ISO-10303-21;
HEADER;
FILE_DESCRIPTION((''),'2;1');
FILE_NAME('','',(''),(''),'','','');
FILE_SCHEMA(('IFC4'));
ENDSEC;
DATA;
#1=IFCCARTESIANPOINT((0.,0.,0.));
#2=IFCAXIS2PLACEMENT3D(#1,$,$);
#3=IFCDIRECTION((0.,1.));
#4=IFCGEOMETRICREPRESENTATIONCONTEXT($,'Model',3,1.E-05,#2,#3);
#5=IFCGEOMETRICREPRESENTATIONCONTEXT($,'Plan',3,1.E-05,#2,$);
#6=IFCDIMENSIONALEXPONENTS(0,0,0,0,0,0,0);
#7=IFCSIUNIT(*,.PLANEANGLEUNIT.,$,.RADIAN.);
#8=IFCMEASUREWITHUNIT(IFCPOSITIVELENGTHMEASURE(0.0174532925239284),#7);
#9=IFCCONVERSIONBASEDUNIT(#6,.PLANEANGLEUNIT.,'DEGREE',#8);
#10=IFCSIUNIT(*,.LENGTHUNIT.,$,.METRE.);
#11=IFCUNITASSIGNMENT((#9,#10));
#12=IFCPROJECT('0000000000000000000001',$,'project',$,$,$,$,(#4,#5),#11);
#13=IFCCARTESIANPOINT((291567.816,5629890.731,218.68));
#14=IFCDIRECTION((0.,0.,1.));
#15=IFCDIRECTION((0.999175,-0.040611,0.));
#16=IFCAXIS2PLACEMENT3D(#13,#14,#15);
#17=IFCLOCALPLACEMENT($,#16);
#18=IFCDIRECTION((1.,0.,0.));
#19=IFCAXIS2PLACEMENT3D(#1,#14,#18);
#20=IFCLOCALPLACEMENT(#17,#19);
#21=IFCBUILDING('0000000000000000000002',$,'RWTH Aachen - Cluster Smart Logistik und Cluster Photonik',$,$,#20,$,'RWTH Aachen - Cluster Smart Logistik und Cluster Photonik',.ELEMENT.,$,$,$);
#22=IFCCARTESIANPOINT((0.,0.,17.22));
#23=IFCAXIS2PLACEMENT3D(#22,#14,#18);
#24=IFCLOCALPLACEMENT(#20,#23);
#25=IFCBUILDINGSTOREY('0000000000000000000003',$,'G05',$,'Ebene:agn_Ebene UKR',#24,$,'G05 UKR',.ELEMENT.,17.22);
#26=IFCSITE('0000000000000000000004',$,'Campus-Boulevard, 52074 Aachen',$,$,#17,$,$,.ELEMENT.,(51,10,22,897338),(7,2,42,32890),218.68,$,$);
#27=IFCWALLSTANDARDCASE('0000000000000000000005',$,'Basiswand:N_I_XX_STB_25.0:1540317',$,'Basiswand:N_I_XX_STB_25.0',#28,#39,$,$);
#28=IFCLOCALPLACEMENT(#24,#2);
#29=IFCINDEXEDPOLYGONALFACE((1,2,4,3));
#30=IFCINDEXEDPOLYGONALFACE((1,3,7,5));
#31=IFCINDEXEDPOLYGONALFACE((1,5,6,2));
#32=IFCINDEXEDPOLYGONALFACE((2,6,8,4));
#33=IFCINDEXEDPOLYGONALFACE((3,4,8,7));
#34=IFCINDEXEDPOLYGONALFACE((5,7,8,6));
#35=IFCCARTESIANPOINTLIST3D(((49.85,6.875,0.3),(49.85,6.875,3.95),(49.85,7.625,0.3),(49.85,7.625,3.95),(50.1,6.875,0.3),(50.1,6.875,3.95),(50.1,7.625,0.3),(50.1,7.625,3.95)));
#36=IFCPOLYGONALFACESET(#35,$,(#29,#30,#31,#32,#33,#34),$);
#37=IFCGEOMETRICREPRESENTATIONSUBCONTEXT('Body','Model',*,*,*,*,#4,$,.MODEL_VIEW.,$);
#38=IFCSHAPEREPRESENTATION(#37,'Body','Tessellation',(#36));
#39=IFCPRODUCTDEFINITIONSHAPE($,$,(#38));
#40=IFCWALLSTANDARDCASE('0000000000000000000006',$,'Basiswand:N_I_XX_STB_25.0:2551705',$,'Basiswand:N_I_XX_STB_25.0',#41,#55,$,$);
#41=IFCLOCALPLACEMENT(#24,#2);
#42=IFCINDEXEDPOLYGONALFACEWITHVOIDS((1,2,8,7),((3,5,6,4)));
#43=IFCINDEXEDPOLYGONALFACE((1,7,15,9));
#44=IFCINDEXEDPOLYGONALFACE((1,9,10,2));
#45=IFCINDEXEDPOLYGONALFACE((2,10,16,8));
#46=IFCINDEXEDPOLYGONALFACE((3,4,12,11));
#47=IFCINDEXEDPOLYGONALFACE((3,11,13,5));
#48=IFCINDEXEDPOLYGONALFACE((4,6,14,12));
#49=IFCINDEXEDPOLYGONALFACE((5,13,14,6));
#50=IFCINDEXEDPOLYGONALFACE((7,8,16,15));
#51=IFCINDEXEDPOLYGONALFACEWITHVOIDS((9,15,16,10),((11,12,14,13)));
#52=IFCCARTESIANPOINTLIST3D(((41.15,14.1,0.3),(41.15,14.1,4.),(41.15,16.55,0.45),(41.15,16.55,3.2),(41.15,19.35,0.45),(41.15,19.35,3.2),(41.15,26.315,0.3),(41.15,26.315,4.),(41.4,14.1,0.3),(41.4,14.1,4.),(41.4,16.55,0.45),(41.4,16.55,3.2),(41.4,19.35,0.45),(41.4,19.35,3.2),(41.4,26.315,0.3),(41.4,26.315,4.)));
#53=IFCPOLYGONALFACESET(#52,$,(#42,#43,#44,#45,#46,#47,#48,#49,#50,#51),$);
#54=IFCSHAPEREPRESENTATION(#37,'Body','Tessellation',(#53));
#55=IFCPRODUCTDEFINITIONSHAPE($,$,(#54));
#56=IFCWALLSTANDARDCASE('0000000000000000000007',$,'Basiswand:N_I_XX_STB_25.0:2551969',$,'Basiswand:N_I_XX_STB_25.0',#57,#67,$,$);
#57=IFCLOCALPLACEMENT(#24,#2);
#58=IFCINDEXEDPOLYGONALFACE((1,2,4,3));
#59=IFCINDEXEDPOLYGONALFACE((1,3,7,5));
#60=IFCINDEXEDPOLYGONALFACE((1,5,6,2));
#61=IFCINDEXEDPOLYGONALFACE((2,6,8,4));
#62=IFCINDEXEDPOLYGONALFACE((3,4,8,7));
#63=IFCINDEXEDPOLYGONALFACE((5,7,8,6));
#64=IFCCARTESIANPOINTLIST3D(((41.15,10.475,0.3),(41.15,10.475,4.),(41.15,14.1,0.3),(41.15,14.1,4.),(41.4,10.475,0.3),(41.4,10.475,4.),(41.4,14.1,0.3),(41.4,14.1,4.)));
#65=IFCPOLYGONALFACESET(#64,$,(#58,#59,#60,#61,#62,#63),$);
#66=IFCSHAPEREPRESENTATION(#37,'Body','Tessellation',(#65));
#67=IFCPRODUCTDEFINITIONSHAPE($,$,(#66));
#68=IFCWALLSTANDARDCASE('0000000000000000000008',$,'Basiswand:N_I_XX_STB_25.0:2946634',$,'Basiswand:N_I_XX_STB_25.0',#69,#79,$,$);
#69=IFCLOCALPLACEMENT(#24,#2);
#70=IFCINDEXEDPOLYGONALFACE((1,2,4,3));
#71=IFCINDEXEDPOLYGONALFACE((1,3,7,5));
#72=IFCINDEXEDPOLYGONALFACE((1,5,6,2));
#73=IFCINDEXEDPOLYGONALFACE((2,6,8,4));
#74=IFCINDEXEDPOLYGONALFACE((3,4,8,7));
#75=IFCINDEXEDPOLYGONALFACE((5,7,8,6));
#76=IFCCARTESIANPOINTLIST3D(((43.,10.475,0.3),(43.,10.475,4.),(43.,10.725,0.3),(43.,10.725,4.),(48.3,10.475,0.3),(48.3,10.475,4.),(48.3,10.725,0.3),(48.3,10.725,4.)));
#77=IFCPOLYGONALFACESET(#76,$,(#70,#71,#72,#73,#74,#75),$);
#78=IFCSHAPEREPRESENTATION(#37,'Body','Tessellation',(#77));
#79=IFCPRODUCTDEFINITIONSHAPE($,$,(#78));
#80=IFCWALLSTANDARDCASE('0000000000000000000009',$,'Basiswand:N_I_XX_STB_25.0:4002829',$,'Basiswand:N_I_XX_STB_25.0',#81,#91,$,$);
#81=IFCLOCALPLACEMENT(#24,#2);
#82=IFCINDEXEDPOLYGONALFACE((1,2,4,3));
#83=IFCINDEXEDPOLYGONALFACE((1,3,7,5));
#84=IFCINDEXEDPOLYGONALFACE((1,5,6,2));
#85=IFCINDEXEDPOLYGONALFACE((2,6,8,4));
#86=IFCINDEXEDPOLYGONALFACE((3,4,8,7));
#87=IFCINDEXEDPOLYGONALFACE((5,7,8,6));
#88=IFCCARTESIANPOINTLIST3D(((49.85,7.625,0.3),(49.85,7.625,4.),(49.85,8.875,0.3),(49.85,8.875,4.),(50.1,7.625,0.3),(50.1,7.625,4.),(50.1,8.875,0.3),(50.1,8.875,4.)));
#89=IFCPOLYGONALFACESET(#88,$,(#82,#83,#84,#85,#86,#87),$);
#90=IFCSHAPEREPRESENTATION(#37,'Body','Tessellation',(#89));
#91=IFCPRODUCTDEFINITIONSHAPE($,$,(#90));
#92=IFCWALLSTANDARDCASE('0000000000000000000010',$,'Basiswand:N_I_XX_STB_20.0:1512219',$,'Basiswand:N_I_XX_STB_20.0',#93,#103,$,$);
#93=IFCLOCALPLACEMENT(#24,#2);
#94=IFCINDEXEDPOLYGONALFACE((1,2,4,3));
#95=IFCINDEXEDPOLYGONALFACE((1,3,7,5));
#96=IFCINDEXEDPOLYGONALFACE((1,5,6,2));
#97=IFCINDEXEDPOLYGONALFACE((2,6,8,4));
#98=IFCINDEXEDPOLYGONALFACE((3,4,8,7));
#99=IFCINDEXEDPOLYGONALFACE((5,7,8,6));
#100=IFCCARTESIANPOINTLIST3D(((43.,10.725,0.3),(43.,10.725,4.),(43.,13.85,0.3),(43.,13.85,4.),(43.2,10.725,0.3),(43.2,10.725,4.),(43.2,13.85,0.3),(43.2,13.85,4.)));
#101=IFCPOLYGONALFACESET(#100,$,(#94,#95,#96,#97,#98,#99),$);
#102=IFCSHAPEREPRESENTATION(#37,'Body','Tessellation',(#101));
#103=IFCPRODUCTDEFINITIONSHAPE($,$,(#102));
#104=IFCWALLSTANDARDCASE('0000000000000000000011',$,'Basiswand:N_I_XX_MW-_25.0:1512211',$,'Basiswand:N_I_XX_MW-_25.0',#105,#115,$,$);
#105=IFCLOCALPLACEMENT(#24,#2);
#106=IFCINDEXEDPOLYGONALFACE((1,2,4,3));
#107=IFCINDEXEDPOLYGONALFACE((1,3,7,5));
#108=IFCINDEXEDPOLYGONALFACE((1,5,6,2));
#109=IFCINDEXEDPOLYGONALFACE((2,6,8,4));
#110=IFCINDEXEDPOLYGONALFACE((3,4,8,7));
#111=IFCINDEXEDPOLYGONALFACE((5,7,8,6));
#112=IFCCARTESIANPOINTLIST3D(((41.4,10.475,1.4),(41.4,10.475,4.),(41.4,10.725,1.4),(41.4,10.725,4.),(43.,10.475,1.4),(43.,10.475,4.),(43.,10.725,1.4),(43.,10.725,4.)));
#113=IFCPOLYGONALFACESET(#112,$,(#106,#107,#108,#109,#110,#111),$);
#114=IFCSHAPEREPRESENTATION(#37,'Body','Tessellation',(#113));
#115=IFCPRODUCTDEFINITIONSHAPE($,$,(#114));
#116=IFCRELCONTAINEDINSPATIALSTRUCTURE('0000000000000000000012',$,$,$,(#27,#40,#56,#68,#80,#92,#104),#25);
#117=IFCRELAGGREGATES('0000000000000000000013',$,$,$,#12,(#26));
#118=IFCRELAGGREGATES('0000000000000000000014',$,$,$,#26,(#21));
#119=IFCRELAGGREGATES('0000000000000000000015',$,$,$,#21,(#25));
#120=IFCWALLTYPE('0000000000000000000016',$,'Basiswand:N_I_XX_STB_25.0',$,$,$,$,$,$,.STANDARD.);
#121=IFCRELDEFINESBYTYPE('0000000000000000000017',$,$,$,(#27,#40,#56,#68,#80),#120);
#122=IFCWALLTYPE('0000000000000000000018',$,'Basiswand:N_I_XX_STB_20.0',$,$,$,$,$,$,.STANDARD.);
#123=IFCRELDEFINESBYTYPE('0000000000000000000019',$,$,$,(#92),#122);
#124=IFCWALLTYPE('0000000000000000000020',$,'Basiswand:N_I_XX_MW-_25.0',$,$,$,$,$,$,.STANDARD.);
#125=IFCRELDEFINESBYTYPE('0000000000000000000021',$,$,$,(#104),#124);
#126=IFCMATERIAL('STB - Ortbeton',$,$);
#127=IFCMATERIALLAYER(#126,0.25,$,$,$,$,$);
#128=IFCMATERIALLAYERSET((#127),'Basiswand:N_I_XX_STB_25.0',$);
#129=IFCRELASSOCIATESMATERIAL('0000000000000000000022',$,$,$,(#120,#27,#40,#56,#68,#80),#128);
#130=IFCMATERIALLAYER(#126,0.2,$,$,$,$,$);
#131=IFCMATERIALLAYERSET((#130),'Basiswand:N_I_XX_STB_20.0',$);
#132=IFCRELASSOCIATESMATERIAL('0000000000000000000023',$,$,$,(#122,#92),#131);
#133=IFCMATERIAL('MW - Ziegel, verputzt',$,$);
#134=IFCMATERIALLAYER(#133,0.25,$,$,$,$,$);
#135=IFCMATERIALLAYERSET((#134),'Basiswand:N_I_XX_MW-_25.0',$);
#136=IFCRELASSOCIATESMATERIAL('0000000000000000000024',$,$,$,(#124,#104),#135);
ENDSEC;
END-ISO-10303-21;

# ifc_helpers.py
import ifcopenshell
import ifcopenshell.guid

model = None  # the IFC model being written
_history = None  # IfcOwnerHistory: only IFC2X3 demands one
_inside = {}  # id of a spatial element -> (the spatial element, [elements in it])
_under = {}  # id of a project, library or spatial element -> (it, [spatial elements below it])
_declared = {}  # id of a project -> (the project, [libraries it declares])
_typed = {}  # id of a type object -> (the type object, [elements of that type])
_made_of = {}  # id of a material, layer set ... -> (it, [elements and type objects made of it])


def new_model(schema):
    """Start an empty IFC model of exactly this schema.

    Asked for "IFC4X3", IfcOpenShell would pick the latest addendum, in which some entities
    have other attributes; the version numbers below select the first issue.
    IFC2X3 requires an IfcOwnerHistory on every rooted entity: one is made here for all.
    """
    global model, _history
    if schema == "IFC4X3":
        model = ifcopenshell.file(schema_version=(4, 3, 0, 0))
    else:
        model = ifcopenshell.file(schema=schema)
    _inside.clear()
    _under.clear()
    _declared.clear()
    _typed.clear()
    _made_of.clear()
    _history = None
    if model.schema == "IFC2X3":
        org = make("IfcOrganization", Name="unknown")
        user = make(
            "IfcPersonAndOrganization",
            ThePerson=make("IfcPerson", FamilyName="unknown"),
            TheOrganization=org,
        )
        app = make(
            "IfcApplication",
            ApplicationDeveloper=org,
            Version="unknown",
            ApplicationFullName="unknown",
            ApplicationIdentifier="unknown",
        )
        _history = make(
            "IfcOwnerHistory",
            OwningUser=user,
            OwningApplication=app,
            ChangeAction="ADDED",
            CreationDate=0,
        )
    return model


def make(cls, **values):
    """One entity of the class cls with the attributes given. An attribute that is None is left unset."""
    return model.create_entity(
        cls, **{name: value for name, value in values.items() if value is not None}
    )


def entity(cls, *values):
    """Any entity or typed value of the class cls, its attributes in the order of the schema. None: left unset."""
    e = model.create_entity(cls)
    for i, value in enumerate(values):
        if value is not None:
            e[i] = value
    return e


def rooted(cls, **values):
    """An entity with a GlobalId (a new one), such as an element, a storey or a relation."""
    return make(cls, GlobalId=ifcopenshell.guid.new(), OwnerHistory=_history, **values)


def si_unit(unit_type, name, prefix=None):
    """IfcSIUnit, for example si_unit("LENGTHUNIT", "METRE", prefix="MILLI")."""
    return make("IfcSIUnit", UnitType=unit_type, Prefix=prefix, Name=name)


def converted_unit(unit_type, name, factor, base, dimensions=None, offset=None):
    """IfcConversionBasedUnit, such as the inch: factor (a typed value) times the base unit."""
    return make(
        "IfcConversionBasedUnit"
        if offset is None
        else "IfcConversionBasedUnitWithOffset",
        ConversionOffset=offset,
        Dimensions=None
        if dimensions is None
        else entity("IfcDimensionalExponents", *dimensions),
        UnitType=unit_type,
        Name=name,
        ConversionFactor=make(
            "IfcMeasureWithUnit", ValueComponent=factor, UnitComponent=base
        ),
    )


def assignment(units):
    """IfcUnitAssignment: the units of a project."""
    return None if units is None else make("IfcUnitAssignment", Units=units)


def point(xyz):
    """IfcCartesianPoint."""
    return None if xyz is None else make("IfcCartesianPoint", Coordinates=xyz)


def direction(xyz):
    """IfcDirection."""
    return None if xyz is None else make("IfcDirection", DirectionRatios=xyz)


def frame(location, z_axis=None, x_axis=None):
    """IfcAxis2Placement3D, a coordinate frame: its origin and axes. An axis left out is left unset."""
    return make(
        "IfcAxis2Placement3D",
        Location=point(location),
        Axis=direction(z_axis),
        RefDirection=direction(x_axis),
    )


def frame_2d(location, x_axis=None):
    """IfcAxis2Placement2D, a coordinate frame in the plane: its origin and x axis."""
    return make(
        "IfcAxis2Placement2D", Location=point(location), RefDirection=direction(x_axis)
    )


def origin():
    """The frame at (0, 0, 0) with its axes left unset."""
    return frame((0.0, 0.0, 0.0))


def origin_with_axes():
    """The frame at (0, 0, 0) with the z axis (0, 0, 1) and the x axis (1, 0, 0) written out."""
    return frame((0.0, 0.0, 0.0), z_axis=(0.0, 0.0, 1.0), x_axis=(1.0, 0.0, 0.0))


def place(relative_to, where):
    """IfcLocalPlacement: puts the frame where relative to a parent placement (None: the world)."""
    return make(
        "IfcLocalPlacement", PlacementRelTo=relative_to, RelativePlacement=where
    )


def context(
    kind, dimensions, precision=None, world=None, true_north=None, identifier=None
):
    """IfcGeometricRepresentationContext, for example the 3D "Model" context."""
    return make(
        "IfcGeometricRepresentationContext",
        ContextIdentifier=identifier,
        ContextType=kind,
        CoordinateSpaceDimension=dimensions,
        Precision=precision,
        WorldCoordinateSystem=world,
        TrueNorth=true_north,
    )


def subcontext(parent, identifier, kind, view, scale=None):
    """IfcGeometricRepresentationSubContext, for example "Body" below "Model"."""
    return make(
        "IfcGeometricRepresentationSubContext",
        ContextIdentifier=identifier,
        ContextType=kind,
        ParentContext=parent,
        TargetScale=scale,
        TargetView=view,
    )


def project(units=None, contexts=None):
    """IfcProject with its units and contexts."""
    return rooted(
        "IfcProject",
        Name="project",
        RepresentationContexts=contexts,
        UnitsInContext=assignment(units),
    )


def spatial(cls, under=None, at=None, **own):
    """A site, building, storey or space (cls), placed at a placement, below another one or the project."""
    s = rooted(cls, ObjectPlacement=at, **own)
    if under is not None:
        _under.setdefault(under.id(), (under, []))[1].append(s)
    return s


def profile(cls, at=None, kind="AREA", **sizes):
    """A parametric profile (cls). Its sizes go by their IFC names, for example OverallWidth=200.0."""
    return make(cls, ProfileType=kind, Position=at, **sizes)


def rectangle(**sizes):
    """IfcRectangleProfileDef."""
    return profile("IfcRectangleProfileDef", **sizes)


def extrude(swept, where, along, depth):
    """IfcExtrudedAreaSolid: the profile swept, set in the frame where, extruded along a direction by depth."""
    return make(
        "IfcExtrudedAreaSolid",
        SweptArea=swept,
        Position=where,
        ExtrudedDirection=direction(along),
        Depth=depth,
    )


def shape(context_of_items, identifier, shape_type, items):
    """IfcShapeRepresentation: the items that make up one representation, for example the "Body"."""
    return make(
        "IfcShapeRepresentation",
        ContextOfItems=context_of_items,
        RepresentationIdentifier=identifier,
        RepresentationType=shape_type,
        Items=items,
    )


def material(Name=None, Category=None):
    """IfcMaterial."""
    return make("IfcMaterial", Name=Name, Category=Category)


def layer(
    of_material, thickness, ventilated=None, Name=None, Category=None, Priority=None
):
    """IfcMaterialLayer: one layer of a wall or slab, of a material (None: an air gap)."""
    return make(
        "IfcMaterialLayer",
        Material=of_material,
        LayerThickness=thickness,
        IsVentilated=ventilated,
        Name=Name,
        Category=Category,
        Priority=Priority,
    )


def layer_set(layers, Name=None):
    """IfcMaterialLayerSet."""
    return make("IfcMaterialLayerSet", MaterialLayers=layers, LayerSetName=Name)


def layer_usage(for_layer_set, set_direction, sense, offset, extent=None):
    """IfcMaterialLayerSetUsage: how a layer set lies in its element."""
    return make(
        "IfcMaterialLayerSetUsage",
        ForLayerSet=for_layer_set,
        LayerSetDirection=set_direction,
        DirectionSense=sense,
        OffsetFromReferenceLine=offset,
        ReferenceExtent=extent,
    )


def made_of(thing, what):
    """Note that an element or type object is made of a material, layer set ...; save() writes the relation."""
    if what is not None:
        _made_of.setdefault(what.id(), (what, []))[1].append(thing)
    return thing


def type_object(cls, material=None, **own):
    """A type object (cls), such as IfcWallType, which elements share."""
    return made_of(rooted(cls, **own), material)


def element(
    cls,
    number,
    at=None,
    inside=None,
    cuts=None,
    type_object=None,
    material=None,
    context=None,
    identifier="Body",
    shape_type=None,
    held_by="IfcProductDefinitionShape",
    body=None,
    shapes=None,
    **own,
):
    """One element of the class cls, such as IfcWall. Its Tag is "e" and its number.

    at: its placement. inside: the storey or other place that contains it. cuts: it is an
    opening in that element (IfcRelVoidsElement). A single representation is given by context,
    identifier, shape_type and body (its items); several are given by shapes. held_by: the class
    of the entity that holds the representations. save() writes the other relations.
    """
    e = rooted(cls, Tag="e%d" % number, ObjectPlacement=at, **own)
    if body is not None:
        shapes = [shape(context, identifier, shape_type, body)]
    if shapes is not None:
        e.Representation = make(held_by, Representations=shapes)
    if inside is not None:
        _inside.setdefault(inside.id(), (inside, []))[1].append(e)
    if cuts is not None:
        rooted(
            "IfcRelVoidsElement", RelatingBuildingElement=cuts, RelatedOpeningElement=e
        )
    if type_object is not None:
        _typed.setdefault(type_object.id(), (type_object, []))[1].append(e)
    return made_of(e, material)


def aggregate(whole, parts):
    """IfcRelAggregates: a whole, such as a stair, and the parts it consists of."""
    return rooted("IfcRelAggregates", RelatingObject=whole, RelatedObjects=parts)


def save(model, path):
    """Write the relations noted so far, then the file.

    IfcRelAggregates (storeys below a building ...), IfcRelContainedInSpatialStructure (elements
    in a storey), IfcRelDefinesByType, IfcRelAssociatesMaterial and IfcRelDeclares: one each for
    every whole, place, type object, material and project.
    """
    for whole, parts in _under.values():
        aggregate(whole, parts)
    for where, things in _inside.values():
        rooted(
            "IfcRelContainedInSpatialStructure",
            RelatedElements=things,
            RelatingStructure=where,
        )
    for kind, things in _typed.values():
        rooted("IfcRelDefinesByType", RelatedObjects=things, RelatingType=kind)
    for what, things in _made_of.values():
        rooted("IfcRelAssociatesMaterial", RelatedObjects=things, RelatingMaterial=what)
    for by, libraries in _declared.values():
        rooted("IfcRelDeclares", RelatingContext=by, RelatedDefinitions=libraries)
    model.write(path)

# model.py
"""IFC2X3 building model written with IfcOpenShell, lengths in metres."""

from ifc_helpers import new_model, entity, si_unit, converted_unit, direction, frame, frame_2d, origin, origin_with_axes, place, context, subcontext, project, spatial, rectangle, extrude, material, layer, layer_set, layer_usage, type_object, element, save


model = new_model("IFC2X3")

# Units and contexts
model_context = context("Model", 3, precision=1e-05, world=origin(), true_north=direction((0.0, 1.0)))
plan_context = context("Plan", 3, precision=1e-05, world=origin())
body_context = subcontext(model_context, "Body", "Model", "MODEL_VIEW")
ifc_project = project(units=[converted_unit("PLANEANGLEUNIT", "DEGREE", entity("IfcPositiveLengthMeasure", 0.0174532925239284), si_unit("PLANEANGLEUNIT", "RADIAN"), dimensions=[0, 0, 0, 0, 0, 0, 0]), si_unit("LENGTHUNIT", "METRE")], contexts=[model_context, plan_context])

# Site, building, storey
site_placement = place(None, frame((291567.816, 5629890.731, 218.68), z_axis=(0.0, 0.0, 1.0), x_axis=(0.999175, -0.040611, 0.0)))
site = spatial("IfcSite", under=ifc_project, at=site_placement, Name="Campus-Boulevard, 52074 Aachen", CompositionType="ELEMENT", RefLatitude=(51, 10, 22, 897338), RefLongitude=(7, 2, 42, 32890), RefElevation=218.68)
building_placement = place(site_placement, origin_with_axes())
building = spatial("IfcBuilding", under=site, at=building_placement, Name="RWTH Aachen - Cluster Smart Logistik und Cluster Photonik", LongName="RWTH Aachen - Cluster Smart Logistik und Cluster Photonik", CompositionType="ELEMENT")
storey_placement = place(building_placement, frame((0.0, 0.0, 17.22), z_axis=(0.0, 0.0, 1.0), x_axis=(1.0, 0.0, 0.0)))
storey = spatial("IfcBuildingStorey", under=building, at=storey_placement, Name="G05", ObjectType="Ebene:agn_Ebene UKR", LongName="G05 UKR", CompositionType="ELEMENT", Elevation=17.22)

# Shared definitions
ifc_material_1 = material(Name="STB - Ortbeton")

# Shared definitions
ifc_layer_1 = layer(ifc_material_1, 0.25)
ifc_layer_set_1 = layer_set([ifc_layer_1], Name="Basiswand:N_I_XX_STB_25.0")
wall_type_1 = type_object("IfcWallType", Name="Basiswand:N_I_XX_STB_25.0", PredefinedType="STANDARD", material=ifc_layer_set_1)

# Wall
ifc_layer_usage_1 = layer_usage(ifc_layer_set_1, "AXIS2", "POSITIVE", -0.125)
wall_1_placement = place(storey_placement, frame((49.975, 6.875, 0.3), z_axis=(0.0, 0.0, 1.0), x_axis=(0.0, 1.0, 0.0)))
element("IfcWallStandardCase", 1, at=wall_1_placement, inside=storey, type_object=wall_type_1, material=ifc_layer_usage_1, Name="Basiswand:N_I_XX_STB_25.0:1540317", ObjectType="Basiswand:N_I_XX_STB_25.0", context=body_context, shape_type="SweptSolid", body=[
    extrude(rectangle(XDim=0.75, YDim=0.25, at=frame_2d((0.375, 0.0), x_axis=(-1.0, 0.0))), origin(), (0.0, 0.0, 1.0), 3.65),
])

# Wall, opening
ifc_layer_usage_2 = layer_usage(ifc_layer_set_1, "AXIS2", "NEGATIVE", 0.125)
wall_2_placement = place(storey_placement, frame((41.275, 14.1, 0.3), z_axis=(0.0, 0.0, 1.0), x_axis=(0.0, 1.0, 0.0)))
wall_2 = element("IfcWallStandardCase", 2, at=wall_2_placement, inside=storey, type_object=wall_type_1, material=ifc_layer_usage_2, Name="Basiswand:N_I_XX_STB_25.0:2551705", ObjectType="Basiswand:N_I_XX_STB_25.0", context=body_context, shape_type="SweptSolid", body=[
    extrude(rectangle(XDim=12.215, YDim=0.25, at=frame_2d((6.1075, 0.0), x_axis=(-1.0, 0.0))), origin(), (0.0, 0.0, 1.0), 3.7),
])
opening_1_placement = place(wall_2_placement, frame((2.45, 0.2774, 0.15), z_axis=(0.0, 0.0, 1.0), x_axis=(1.0, 0.0, 0.0)))
element("IfcOpeningElement", 3, at=opening_1_placement, cuts=wall_2, ObjectType="Opening", context=body_context, shape_type="SweptSolid", body=[
    extrude(rectangle(XDim=2.75, YDim=2.8, at=frame_2d((0.0, 0.0), x_axis=(0.0, 1.0))), frame((1.4, -0.5548, 1.375), z_axis=(0.0, 1.0, 0.0), x_axis=(-1.0, 0.0, 0.0)), (0.0, 0.0, 1.0), 0.5548),
])

# Walls
ifc_layer_usage_3 = layer_usage(ifc_layer_set_1, "AXIS2", "NEGATIVE", 0.125)
wall_3_placement = place(storey_placement, frame((41.275, 10.475, 0.3), z_axis=(0.0, 0.0, 1.0), x_axis=(0.0, 1.0, 0.0)))
element("IfcWallStandardCase", 4, at=wall_3_placement, inside=storey, type_object=wall_type_1, material=ifc_layer_usage_3, Name="Basiswand:N_I_XX_STB_25.0:2551969", ObjectType="Basiswand:N_I_XX_STB_25.0", context=body_context, shape_type="SweptSolid", body=[
    extrude(rectangle(XDim=3.625, YDim=0.25, at=frame_2d((1.8125, 0.0), x_axis=(-1.0, 0.0))), origin(), (0.0, 0.0, 1.0), 3.7),
])
ifc_layer_usage_4 = layer_usage(ifc_layer_set_1, "AXIS2", "NEGATIVE", 0.125)
wall_4_placement = place(storey_placement, frame((43.0, 10.6, 0.3), z_axis=(0.0, 0.0, 1.0), x_axis=(1.0, 0.0, 0.0)))
element("IfcWallStandardCase", 5, at=wall_4_placement, inside=storey, type_object=wall_type_1, material=ifc_layer_usage_4, Name="Basiswand:N_I_XX_STB_25.0:2946634", ObjectType="Basiswand:N_I_XX_STB_25.0", context=body_context, shape_type="SweptSolid", body=[
    extrude(rectangle(XDim=5.3, YDim=0.25, at=frame_2d((2.65, 0.0), x_axis=(-1.0, 0.0))), origin(), (0.0, 0.0, 1.0), 3.7),
])
ifc_layer_usage_5 = layer_usage(ifc_layer_set_1, "AXIS2", "POSITIVE", -0.125)
wall_5_placement = place(storey_placement, frame((49.975, 7.625, 0.3), z_axis=(0.0, 0.0, 1.0), x_axis=(0.0, 1.0, 0.0)))
element("IfcWallStandardCase", 6, at=wall_5_placement, inside=storey, type_object=wall_type_1, material=ifc_layer_usage_5, Name="Basiswand:N_I_XX_STB_25.0:4002829", ObjectType="Basiswand:N_I_XX_STB_25.0", context=body_context, shape_type="SweptSolid", body=[
    extrude(rectangle(XDim=1.25, YDim=0.25, at=frame_2d((0.625, 0.0), x_axis=(-1.0, 0.0))), origin(), (0.0, 0.0, 1.0), 3.7),
])
ifc_layer_2 = layer(ifc_material_1, 0.2)
ifc_layer_set_2 = layer_set([ifc_layer_2], Name="Basiswand:N_I_XX_STB_20.0")
ifc_layer_usage_6 = layer_usage(ifc_layer_set_2, "AXIS2", "NEGATIVE", 0.1)
wall_type_2 = type_object("IfcWallType", Name="Basiswand:N_I_XX_STB_20.0", PredefinedType="STANDARD", material=ifc_layer_set_2)
wall_6_placement = place(storey_placement, frame((43.1, 13.85, 0.3), z_axis=(0.0, 0.0, 1.0), x_axis=(0.0, -1.0, 0.0)))
element("IfcWallStandardCase", 7, at=wall_6_placement, inside=storey, type_object=wall_type_2, material=ifc_layer_usage_6, Name="Basiswand:N_I_XX_STB_20.0:1512219", ObjectType="Basiswand:N_I_XX_STB_20.0", context=body_context, shape_type="SweptSolid", body=[
    extrude(rectangle(XDim=3.125, YDim=0.2, at=frame_2d((1.5625, 0.0), x_axis=(-1.0, 0.0))), origin(), (0.0, 0.0, 1.0), 3.7),
])
ifc_material_2 = material(Name="MW - Ziegel, verputzt")
ifc_layer_3 = layer(ifc_material_2, 0.25)
ifc_layer_set_3 = layer_set([ifc_layer_3], Name="Basiswand:N_I_XX_MW-_25.0")
ifc_layer_usage_7 = layer_usage(ifc_layer_set_3, "AXIS2", "NEGATIVE", 0.125)
wall_type_3 = type_object("IfcWallType", Name="Basiswand:N_I_XX_MW-_25.0", PredefinedType="STANDARD", material=ifc_layer_set_3)
wall_7_placement = place(storey_placement, frame((41.4, 10.6, 1.4), z_axis=(0.0, 0.0, 1.0), x_axis=(1.0, 0.0, 0.0)))
element("IfcWallStandardCase", 8, at=wall_7_placement, inside=storey, type_object=wall_type_3, material=ifc_layer_usage_7, Name="Basiswand:N_I_XX_MW-_25.0:1512211", ObjectType="Basiswand:N_I_XX_MW-_25.0", context=body_context, shape_type="SweptSolid", body=[
    extrude(rectangle(XDim=1.6, YDim=0.25, at=frame_2d((0.8, 0.0), x_axis=(-1.0, 0.0))), origin(), (0.0, 0.0, 1.0), 2.6),
])

save(model, "model.ifc")
